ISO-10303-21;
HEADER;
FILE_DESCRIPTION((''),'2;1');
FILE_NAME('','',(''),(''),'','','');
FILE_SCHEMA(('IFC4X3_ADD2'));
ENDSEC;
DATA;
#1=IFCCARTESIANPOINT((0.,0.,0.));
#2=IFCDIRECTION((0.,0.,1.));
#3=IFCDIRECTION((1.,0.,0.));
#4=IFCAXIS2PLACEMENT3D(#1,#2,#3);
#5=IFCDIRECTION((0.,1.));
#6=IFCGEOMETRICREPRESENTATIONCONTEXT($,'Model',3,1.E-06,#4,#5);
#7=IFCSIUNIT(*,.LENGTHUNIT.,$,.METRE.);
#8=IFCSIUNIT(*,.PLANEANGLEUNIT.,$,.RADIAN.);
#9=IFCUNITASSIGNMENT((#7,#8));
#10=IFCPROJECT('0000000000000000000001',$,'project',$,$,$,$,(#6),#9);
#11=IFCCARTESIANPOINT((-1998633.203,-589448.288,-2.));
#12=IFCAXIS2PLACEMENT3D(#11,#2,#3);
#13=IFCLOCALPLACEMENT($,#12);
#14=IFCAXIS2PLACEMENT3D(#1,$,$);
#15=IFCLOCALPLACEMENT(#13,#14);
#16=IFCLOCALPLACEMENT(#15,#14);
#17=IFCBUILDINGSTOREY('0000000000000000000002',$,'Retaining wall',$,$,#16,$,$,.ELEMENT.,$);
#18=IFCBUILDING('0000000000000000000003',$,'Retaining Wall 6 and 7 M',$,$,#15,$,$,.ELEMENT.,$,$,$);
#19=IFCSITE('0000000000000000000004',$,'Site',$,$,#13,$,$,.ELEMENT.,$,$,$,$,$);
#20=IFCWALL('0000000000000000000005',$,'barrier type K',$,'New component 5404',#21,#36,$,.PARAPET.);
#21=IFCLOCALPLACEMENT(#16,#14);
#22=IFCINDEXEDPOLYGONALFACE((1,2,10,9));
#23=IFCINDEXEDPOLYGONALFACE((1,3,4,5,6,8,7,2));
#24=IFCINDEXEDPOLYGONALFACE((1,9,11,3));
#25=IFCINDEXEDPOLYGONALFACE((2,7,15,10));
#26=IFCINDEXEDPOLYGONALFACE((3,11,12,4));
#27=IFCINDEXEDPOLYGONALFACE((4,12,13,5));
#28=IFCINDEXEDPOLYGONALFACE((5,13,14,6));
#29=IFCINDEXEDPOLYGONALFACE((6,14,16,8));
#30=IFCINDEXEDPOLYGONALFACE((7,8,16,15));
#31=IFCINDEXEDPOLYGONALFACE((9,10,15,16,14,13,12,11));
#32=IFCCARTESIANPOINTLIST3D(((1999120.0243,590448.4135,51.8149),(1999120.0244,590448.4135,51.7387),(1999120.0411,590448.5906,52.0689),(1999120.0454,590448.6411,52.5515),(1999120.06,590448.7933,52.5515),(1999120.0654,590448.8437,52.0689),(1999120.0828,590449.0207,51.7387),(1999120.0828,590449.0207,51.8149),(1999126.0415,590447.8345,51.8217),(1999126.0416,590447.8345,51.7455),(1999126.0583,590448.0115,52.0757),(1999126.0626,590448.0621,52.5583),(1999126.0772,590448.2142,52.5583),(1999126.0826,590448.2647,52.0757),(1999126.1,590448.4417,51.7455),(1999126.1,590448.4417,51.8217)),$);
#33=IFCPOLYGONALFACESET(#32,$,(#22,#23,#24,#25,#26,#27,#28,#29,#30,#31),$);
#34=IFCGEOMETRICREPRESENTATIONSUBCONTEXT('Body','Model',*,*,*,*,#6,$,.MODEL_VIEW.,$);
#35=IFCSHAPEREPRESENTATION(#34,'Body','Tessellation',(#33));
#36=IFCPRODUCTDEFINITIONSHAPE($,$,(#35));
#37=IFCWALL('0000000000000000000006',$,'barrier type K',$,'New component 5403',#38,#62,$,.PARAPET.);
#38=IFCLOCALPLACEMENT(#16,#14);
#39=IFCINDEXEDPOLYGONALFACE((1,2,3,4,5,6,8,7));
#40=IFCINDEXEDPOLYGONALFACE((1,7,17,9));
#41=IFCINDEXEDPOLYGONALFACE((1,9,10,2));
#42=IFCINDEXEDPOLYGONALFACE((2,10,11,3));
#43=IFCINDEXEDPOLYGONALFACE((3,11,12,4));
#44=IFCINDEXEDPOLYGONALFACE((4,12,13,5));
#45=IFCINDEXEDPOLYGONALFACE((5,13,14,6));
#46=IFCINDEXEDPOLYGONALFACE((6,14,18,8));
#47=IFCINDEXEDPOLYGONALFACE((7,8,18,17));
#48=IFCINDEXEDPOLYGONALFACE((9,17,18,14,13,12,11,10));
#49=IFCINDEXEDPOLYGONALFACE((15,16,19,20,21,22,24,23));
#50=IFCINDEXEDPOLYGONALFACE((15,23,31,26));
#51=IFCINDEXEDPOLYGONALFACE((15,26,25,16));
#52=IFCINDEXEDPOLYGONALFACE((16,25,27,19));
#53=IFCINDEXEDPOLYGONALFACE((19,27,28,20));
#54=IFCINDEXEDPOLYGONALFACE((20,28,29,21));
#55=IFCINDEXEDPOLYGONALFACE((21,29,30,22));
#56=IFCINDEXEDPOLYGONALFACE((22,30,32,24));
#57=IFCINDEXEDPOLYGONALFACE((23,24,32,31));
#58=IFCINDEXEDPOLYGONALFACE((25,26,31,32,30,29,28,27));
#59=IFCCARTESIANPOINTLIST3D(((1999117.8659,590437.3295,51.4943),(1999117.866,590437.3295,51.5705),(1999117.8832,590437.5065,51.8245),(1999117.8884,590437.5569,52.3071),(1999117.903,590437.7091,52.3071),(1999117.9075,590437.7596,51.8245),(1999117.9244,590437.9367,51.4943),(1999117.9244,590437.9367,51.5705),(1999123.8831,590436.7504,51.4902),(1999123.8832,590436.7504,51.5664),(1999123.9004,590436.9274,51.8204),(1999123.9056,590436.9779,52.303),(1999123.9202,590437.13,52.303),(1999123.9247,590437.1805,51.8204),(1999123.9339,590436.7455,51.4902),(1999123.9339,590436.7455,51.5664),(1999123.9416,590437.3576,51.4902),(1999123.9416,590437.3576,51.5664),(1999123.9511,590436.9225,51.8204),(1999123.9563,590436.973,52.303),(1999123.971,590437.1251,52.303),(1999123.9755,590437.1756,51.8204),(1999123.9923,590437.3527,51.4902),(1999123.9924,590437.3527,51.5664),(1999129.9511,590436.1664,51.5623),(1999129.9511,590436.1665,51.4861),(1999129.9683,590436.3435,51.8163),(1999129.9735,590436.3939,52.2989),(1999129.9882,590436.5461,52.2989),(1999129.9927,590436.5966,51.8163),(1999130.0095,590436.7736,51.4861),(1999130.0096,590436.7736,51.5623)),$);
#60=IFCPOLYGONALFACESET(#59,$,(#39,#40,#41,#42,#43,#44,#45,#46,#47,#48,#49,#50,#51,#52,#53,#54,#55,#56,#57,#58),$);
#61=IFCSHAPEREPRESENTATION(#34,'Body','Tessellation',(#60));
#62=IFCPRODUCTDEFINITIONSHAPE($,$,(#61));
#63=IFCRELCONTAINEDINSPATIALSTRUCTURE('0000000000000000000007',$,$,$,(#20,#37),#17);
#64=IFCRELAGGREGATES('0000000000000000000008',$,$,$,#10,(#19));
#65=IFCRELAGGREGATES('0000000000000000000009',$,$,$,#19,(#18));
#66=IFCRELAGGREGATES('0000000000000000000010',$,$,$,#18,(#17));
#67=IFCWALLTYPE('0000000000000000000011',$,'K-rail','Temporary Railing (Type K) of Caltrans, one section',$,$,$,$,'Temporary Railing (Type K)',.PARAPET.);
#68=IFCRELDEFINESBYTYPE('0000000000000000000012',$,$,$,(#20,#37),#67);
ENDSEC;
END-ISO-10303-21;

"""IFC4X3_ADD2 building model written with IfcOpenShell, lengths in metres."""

from ifc_helpers import new_model, si_unit, direction, frame, origin, origin_with_axes, place, context, subcontext, project, spatial, polyline, outline, extrude, source, transform, mapped, type_object, type_shapes, element, save


model = new_model("IFC4X3_ADD2")

# Units and contexts
model_context = context("Model", 3, precision=1e-06, world=origin_with_axes(), true_north=direction((0.0, 1.0)))
body_context = subcontext(model_context, "Body", "Model", "MODEL_VIEW")
ifc_project = project(units=[si_unit("LENGTHUNIT", "METRE"), si_unit("PLANEANGLEUNIT", "RADIAN")], contexts=[model_context])

# Site, building, storey
site_placement = place(None, frame((-1998633.203, -589448.288, -2.0), z_axis=(0.0, 0.0, 1.0), x_axis=(1.0, 0.0, 0.0)))
site = spatial("IfcSite", under=ifc_project, at=site_placement, Name="Site", CompositionType="ELEMENT")
building_placement = place(site_placement, origin())
building = spatial("IfcBuilding", under=site, at=building_placement, Name="Retaining Wall 6 and 7 M", CompositionType="ELEMENT")
storey_placement = place(building_placement, origin())
storey = spatial("IfcBuildingStorey", under=building, at=storey_placement, Name="Retaining wall", CompositionType="ELEMENT")

# Walls
wall_type = type_object("IfcWallType", Name="K-rail", Description="Temporary Railing (Type K) of Caltrans, one section", ElementType="Temporary Railing (Type K)", PredefinedType="PARAPET")
shared_shape = source(origin(), body_context, "Body", "SweptSolid", [
    extrude(outline(polyline([(0.305, 0.0), (0.305, 0.0762), (0.1271, 0.3302), (0.0764, 0.8128), (-0.0764, 0.8128), (-0.1271, 0.3302), (-0.305, 0.0762), (-0.305, 0.0), (0.305, 0.0)])), origin(), (0.0, 0.0, 1.0), 6.045),
])
type_shapes(wall_type, [shared_shape])
wall_1_placement = place(storey_placement, frame((2000000.0, 590000.0, 0.0), z_axis=(0.0, 0.0, 1.0), x_axis=(1.0, 0.0, 0.0)))
element("IfcWall", 1, at=wall_1_placement, inside=storey, type_object=wall_type, Name="barrier type K", ObjectType="New component 5404", PredefinedType="PARAPET", context=body_context, shape_type="MappedRepresentation", body=[
    mapped(shared_shape, transform((-879.9464, 448.7171, 51.7387), x_axis=(0.09579, 0.995402, 0.0), y_axis=(-0.001112, 0.000107, 0.999999), z_axis=(0.995401, -0.09579, 0.001117), scale=1.0)),
])
wall_2_placement = place(storey_placement, frame((2000000.0, 590000.0, 0.0), z_axis=(0.0, 0.0, 1.0), x_axis=(1.0, 0.0, 0.0)))
element("IfcWall", 2, at=wall_2_placement, inside=storey, type_object=wall_type, Name="barrier type K", ObjectType="New component 5403", PredefinedType="PARAPET", context=body_context, shape_type="MappedRepresentation", body=[
    mapped(shared_shape, transform((-882.1049, 437.6331, 51.4943), x_axis=(0.095795, 0.995401, 0.0), y_axis=(0.000675, -0.000065, 1.0), z_axis=(0.995401, -0.095795, -0.000678), scale=1.0)),
    mapped(shared_shape, transform((-876.0369, 437.0491, 51.4902), x_axis=(0.095791, 0.995401, 0.0), y_axis=(0.00067, -0.000064, 1.0), z_axis=(0.995401, -0.095791, -0.000673), scale=1.0)),
])

save(model, "model.ifc")
